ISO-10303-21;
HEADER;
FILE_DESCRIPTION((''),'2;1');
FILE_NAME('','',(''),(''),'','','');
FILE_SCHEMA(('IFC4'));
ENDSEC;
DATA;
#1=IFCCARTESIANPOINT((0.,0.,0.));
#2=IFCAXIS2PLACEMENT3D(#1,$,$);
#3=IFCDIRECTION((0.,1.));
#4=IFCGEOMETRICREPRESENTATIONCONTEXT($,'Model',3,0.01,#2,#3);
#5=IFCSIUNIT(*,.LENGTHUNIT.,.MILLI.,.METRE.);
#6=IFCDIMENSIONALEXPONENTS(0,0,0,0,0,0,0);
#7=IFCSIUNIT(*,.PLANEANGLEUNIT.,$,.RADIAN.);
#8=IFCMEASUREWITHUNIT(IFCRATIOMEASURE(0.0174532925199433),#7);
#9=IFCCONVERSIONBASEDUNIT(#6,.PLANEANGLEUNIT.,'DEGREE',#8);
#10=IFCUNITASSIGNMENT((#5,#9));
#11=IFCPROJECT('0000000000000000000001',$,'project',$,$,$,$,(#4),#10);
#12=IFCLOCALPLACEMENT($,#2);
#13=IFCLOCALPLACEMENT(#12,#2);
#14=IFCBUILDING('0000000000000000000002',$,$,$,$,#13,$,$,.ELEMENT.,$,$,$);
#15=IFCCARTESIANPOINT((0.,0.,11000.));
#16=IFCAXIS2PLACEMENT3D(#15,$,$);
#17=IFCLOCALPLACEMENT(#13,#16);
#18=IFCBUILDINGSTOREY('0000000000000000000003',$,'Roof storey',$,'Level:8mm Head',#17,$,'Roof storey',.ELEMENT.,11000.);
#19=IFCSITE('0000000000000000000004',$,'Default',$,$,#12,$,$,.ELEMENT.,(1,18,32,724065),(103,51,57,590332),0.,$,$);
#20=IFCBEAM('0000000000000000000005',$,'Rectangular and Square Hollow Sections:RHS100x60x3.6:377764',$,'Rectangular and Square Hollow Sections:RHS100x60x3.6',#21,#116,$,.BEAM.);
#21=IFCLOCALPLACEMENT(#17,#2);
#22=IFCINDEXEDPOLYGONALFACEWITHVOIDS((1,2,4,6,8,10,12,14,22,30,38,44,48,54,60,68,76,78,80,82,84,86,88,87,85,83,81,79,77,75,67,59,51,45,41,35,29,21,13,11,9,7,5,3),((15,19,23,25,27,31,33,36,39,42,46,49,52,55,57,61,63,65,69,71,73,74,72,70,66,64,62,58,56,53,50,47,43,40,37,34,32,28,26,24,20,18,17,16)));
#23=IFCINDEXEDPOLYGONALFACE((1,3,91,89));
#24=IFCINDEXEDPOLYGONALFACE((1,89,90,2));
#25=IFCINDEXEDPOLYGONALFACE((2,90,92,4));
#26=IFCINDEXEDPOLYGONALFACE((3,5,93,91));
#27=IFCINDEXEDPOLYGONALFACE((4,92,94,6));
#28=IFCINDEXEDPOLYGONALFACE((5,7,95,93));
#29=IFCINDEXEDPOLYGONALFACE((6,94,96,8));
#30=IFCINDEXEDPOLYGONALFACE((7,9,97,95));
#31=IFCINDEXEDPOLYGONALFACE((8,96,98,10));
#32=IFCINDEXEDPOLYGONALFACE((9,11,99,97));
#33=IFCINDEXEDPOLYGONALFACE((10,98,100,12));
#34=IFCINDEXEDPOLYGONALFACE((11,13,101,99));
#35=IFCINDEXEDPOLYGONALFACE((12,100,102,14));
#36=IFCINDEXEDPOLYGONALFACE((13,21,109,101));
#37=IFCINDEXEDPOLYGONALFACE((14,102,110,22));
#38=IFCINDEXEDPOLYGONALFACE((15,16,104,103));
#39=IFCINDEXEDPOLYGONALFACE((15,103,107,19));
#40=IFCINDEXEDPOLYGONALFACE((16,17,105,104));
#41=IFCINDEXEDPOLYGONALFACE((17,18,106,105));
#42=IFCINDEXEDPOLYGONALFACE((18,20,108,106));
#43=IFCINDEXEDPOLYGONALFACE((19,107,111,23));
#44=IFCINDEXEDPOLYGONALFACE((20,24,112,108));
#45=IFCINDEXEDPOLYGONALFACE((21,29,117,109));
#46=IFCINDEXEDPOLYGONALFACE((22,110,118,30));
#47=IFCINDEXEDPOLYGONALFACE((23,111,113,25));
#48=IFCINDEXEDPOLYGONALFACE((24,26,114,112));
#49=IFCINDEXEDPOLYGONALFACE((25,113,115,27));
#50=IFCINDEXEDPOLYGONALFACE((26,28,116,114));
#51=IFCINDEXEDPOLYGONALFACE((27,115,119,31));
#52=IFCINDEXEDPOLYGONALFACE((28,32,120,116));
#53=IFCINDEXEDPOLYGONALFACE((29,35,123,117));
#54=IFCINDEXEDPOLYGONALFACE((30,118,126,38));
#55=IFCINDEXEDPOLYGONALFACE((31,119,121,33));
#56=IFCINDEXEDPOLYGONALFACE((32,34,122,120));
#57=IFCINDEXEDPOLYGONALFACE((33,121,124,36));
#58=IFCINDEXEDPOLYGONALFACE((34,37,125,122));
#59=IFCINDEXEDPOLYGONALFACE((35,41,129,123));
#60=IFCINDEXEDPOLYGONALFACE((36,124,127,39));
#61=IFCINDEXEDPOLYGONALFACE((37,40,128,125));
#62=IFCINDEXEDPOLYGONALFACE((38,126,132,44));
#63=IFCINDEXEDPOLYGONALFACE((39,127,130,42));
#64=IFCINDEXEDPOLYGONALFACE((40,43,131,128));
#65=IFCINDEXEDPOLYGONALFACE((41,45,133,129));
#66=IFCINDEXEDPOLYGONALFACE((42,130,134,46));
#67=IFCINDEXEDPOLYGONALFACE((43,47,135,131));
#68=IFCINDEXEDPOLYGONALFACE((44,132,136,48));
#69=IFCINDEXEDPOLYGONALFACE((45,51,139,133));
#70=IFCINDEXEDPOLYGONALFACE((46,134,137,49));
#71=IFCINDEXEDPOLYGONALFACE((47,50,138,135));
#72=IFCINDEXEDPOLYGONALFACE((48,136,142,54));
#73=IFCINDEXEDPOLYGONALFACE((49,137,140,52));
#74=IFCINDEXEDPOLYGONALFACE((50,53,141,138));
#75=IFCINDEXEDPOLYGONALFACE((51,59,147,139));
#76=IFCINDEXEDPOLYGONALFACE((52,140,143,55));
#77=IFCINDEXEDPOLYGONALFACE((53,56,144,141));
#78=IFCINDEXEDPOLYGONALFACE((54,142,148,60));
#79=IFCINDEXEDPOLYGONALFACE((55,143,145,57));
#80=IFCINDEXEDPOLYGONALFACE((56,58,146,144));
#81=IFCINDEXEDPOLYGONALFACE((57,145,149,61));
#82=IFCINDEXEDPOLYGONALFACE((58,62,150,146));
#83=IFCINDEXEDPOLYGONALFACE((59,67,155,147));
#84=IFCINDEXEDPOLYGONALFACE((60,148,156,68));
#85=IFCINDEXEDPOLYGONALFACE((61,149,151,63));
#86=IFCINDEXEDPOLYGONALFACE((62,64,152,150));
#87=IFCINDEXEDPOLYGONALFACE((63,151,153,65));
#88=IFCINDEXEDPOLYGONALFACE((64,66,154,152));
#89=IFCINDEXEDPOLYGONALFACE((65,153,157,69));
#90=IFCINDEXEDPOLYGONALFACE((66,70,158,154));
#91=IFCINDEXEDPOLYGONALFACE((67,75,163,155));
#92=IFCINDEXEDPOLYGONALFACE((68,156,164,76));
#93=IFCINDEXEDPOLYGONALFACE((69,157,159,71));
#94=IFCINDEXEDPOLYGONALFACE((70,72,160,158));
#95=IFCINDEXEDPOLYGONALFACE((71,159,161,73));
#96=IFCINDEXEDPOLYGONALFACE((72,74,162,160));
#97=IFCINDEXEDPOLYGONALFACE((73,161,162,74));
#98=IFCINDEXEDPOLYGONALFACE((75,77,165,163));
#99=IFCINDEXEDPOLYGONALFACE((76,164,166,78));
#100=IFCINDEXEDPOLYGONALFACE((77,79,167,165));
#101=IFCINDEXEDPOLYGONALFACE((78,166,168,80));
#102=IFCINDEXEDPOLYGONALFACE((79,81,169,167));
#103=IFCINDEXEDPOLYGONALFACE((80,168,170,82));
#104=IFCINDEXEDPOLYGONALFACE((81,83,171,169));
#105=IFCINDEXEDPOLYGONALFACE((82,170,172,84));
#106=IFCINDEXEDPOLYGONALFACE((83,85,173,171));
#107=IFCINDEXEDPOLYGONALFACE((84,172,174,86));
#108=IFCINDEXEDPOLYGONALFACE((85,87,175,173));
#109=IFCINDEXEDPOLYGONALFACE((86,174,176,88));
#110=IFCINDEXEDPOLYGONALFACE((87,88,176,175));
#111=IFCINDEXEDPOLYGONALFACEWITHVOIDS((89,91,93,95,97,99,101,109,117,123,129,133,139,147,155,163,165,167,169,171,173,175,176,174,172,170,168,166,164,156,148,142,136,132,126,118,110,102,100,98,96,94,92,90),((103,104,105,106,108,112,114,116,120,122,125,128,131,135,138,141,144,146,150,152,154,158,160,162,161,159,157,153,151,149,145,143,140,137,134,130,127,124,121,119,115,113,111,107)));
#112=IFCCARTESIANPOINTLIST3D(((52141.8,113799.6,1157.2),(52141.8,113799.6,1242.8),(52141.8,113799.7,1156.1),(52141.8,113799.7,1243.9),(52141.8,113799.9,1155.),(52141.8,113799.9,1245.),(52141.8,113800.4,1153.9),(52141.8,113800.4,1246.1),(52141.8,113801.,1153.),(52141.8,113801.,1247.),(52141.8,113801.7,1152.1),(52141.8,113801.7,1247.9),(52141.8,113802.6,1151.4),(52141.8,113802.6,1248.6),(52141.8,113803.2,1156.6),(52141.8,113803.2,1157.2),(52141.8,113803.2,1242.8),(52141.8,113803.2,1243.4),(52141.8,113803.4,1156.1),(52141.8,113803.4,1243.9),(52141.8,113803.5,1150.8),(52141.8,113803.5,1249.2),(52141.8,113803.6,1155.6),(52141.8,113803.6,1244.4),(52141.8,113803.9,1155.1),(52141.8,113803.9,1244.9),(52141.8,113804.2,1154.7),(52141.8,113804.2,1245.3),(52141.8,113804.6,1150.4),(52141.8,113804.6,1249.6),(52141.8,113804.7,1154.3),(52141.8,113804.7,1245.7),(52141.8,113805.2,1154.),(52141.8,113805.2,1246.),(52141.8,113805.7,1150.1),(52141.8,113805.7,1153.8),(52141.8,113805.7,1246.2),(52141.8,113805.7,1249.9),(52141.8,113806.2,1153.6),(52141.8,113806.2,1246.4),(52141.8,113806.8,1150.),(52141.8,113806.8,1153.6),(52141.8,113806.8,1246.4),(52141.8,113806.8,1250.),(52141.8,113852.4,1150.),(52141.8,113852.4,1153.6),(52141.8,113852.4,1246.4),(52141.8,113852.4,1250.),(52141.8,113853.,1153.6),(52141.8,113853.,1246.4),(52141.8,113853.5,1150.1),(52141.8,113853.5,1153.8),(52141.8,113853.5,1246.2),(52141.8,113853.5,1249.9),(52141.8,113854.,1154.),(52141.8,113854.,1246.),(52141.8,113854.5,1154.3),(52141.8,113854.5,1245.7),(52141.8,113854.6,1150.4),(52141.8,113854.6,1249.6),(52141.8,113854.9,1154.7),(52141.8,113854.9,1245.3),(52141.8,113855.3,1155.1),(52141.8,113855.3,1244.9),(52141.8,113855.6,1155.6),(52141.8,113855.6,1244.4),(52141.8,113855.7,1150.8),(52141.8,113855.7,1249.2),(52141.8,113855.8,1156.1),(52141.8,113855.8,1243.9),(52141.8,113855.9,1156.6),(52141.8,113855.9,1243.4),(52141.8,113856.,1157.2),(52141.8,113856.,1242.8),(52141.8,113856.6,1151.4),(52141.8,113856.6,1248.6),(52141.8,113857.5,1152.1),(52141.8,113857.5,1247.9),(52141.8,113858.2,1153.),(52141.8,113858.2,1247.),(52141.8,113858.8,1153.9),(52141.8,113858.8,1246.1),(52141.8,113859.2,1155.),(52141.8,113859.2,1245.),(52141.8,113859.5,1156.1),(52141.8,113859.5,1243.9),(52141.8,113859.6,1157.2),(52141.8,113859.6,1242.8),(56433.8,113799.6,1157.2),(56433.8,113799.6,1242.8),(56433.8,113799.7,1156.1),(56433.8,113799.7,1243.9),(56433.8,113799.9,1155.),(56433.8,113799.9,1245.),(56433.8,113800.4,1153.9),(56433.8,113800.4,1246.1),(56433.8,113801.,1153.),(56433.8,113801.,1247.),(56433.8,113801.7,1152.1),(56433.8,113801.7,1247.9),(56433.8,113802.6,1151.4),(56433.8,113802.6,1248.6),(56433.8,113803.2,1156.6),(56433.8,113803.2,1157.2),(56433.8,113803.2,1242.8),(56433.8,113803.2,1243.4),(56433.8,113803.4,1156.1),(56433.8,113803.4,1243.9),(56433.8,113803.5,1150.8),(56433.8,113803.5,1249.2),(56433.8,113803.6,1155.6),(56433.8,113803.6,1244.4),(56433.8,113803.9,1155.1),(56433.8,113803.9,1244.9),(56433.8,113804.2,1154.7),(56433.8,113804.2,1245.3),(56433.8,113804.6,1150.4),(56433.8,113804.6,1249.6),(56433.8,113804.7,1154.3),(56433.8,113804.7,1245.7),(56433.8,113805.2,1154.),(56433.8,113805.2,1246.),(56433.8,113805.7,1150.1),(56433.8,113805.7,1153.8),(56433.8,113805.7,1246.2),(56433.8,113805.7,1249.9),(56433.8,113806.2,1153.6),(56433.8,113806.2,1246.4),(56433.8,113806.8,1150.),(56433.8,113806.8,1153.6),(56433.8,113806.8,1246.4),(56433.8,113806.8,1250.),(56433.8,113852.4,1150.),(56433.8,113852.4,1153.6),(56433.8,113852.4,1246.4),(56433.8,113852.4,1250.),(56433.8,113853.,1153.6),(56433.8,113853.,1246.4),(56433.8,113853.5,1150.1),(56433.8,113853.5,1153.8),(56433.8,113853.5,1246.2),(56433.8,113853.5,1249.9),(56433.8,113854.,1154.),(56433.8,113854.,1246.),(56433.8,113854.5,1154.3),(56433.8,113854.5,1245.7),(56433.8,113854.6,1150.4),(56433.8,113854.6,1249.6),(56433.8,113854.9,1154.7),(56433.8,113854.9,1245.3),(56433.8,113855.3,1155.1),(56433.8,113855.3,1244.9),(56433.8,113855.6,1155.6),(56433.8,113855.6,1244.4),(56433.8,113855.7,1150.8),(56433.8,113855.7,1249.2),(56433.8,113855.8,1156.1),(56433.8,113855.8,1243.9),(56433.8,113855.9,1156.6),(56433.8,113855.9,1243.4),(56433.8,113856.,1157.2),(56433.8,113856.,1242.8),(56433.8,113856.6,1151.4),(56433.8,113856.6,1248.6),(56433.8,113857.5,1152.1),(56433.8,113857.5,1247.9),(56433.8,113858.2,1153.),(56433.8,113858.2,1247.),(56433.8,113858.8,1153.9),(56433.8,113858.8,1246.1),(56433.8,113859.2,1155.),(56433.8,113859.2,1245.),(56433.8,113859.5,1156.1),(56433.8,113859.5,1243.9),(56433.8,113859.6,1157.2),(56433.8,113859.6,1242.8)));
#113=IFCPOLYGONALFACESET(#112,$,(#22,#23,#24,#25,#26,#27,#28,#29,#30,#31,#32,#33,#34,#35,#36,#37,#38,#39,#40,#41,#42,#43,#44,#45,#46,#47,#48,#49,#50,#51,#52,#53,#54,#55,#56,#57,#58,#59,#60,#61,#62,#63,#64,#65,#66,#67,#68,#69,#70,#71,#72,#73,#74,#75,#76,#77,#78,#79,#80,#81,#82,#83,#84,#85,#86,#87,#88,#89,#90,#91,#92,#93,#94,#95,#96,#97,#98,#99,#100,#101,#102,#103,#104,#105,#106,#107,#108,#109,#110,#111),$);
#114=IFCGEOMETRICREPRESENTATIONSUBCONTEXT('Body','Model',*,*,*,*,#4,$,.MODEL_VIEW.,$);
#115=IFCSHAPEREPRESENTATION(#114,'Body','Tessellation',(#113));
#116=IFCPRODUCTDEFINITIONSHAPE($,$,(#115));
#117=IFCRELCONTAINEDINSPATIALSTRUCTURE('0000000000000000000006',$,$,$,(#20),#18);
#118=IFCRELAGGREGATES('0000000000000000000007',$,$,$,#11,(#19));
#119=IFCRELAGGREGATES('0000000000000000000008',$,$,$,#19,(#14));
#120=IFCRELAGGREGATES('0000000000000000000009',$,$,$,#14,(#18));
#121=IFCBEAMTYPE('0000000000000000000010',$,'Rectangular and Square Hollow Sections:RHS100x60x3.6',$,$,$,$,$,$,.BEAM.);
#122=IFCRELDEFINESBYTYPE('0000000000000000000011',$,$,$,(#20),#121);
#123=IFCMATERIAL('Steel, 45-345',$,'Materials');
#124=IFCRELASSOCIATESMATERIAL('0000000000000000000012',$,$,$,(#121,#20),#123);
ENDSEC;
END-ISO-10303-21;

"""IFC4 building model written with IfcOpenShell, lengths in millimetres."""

from ifc_helpers import new_model, entity, si_unit, converted_unit, direction, frame, origin, place, context, subcontext, project, spatial, indexed_curve, outline, extrude, source, transform, mapped, material, type_object, type_shapes, element, save


model = new_model("IFC4")

# Units and contexts
model_context = context("Model", 3, precision=0.01, world=origin(), true_north=direction((0.0, 1.0)))
body_context = subcontext(model_context, "Body", "Model", "MODEL_VIEW")
ifc_project = project(units=[si_unit("LENGTHUNIT", "METRE", prefix="MILLI"), converted_unit("PLANEANGLEUNIT", "DEGREE", entity("IfcRatioMeasure", 0.0174532925199433), si_unit("PLANEANGLEUNIT", "RADIAN"), dimensions=[0, 0, 0, 0, 0, 0, 0])], contexts=[model_context])

# Site, building, storey
site_placement = place(None, origin())
site = spatial("IfcSite", under=ifc_project, at=site_placement, Name="Default", CompositionType="ELEMENT", RefLatitude=(1, 18, 32, 724065), RefLongitude=(103, 51, 57, 590332), RefElevation=0.0)
building_placement = place(site_placement, origin())
building = spatial("IfcBuilding", under=site, at=building_placement, CompositionType="ELEMENT")
storey_placement = place(building_placement, frame((0.0, 0.0, 11000.0)))
storey = spatial("IfcBuildingStorey", under=building, at=storey_placement, Name="Roof storey", ObjectType="Level:8mm Head", LongName="Roof storey", CompositionType="ELEMENT", Elevation=11000.0)

# Shared definitions
ifc_material = material(Name="Steel, 45-345", Category="Materials")

# Beam
beam_type_1 = type_object("IfcBeamType", Name="Rectangular and Square Hollow Sections:RHS100x60x3.6", PredefinedType="BEAM", material=ifc_material)
shared_shape_1 = source(origin(), body_context, "Body", "SweptSolid", [
    extrude(outline(indexed_curve([(-30.0, -42.8), (-29.9, -43.9), (-29.6, -45.0), (-29.2, -46.1), (-28.6, -47.0), (-27.9, -47.9), (-27.0, -48.6), (-26.1, -49.2), (-25.0, -49.6), (-23.9, -49.9), (-22.8, -50.0), (22.8, -50.0), (23.9, -49.9), (25.0, -49.6), (26.1, -49.2), (27.0, -48.6), (27.9, -47.9), (28.6, -47.0), (29.2, -46.1), (29.6, -45.0), (29.9, -43.9), (30.0, -42.8), (30.0, 42.8), (29.9, 43.9), (29.6, 45.0), (29.2, 46.1), (28.6, 47.0), (27.9, 47.9), (27.0, 48.6), (26.1, 49.2), (25.0, 49.6), (23.9, 49.9), (22.8, 50.0), (-22.8, 50.0), (-23.9, 49.9), (-25.0, 49.6), (-26.1, 49.2), (-27.0, 48.6), (-27.9, 47.9), (-28.6, 47.0), (-29.2, 46.1), (-29.6, 45.0), (-29.9, 43.9), (-30.0, 42.8), (-30.0, -42.8)], self_intersect=False), holes=[indexed_curve([(22.8, -46.4), (-22.8, -46.4), (-23.4, -46.4), (-23.9, -46.2), (-24.4, -46.0), (-24.9, -45.7), (-25.3, -45.3), (-25.7, -44.9), (-26.0, -44.4), (-26.2, -43.9), (-26.4, -43.4), (-26.4, -42.8), (-26.4, 42.8), (-26.4, 43.4), (-26.2, 43.9), (-26.0, 44.4), (-25.7, 44.9), (-25.3, 45.3), (-24.9, 45.7), (-24.4, 46.0), (-23.9, 46.2), (-23.4, 46.4), (-22.8, 46.4), (22.8, 46.4), (23.4, 46.4), (23.9, 46.2), (24.4, 46.0), (24.9, 45.7), (25.3, 45.3), (25.7, 44.9), (26.0, 44.4), (26.2, 43.9), (26.4, 43.4), (26.4, 42.8), (26.4, -42.8), (26.4, -43.4), (26.2, -43.9), (26.0, -44.4), (25.7, -44.9), (25.3, -45.3), (24.9, -45.7), (24.4, -46.0), (23.9, -46.2), (23.4, -46.4), (22.8, -46.4)], self_intersect=False)]), frame((-2152.5, 0.0, 0.0), z_axis=(1.0, 0.0, 0.0), x_axis=(0.0, -1.0, 0.0)), (0.0, 0.0, 1.0), 4292.0),
])
type_shapes(beam_type_1, [shared_shape_1])
for number, where, name in (
    (1, (54294.3, 113829.6, 1200.0), "Rectangular and Square Hollow Sections:RHS100x60x3.6:377764"),
):
    element("IfcBeam", number, at=place(storey_placement, frame(where)), inside=storey, type_object=beam_type_1, material=ifc_material, Name=name, ObjectType="Rectangular and Square Hollow Sections:RHS100x60x3.6", PredefinedType="BEAM", context=body_context, shape_type="MappedRepresentation", body=[
        mapped(shared_shape_1, transform((0.0, 0.0, 0.0), scale=1.0)),
    ])

save(model, "model.ifc")
